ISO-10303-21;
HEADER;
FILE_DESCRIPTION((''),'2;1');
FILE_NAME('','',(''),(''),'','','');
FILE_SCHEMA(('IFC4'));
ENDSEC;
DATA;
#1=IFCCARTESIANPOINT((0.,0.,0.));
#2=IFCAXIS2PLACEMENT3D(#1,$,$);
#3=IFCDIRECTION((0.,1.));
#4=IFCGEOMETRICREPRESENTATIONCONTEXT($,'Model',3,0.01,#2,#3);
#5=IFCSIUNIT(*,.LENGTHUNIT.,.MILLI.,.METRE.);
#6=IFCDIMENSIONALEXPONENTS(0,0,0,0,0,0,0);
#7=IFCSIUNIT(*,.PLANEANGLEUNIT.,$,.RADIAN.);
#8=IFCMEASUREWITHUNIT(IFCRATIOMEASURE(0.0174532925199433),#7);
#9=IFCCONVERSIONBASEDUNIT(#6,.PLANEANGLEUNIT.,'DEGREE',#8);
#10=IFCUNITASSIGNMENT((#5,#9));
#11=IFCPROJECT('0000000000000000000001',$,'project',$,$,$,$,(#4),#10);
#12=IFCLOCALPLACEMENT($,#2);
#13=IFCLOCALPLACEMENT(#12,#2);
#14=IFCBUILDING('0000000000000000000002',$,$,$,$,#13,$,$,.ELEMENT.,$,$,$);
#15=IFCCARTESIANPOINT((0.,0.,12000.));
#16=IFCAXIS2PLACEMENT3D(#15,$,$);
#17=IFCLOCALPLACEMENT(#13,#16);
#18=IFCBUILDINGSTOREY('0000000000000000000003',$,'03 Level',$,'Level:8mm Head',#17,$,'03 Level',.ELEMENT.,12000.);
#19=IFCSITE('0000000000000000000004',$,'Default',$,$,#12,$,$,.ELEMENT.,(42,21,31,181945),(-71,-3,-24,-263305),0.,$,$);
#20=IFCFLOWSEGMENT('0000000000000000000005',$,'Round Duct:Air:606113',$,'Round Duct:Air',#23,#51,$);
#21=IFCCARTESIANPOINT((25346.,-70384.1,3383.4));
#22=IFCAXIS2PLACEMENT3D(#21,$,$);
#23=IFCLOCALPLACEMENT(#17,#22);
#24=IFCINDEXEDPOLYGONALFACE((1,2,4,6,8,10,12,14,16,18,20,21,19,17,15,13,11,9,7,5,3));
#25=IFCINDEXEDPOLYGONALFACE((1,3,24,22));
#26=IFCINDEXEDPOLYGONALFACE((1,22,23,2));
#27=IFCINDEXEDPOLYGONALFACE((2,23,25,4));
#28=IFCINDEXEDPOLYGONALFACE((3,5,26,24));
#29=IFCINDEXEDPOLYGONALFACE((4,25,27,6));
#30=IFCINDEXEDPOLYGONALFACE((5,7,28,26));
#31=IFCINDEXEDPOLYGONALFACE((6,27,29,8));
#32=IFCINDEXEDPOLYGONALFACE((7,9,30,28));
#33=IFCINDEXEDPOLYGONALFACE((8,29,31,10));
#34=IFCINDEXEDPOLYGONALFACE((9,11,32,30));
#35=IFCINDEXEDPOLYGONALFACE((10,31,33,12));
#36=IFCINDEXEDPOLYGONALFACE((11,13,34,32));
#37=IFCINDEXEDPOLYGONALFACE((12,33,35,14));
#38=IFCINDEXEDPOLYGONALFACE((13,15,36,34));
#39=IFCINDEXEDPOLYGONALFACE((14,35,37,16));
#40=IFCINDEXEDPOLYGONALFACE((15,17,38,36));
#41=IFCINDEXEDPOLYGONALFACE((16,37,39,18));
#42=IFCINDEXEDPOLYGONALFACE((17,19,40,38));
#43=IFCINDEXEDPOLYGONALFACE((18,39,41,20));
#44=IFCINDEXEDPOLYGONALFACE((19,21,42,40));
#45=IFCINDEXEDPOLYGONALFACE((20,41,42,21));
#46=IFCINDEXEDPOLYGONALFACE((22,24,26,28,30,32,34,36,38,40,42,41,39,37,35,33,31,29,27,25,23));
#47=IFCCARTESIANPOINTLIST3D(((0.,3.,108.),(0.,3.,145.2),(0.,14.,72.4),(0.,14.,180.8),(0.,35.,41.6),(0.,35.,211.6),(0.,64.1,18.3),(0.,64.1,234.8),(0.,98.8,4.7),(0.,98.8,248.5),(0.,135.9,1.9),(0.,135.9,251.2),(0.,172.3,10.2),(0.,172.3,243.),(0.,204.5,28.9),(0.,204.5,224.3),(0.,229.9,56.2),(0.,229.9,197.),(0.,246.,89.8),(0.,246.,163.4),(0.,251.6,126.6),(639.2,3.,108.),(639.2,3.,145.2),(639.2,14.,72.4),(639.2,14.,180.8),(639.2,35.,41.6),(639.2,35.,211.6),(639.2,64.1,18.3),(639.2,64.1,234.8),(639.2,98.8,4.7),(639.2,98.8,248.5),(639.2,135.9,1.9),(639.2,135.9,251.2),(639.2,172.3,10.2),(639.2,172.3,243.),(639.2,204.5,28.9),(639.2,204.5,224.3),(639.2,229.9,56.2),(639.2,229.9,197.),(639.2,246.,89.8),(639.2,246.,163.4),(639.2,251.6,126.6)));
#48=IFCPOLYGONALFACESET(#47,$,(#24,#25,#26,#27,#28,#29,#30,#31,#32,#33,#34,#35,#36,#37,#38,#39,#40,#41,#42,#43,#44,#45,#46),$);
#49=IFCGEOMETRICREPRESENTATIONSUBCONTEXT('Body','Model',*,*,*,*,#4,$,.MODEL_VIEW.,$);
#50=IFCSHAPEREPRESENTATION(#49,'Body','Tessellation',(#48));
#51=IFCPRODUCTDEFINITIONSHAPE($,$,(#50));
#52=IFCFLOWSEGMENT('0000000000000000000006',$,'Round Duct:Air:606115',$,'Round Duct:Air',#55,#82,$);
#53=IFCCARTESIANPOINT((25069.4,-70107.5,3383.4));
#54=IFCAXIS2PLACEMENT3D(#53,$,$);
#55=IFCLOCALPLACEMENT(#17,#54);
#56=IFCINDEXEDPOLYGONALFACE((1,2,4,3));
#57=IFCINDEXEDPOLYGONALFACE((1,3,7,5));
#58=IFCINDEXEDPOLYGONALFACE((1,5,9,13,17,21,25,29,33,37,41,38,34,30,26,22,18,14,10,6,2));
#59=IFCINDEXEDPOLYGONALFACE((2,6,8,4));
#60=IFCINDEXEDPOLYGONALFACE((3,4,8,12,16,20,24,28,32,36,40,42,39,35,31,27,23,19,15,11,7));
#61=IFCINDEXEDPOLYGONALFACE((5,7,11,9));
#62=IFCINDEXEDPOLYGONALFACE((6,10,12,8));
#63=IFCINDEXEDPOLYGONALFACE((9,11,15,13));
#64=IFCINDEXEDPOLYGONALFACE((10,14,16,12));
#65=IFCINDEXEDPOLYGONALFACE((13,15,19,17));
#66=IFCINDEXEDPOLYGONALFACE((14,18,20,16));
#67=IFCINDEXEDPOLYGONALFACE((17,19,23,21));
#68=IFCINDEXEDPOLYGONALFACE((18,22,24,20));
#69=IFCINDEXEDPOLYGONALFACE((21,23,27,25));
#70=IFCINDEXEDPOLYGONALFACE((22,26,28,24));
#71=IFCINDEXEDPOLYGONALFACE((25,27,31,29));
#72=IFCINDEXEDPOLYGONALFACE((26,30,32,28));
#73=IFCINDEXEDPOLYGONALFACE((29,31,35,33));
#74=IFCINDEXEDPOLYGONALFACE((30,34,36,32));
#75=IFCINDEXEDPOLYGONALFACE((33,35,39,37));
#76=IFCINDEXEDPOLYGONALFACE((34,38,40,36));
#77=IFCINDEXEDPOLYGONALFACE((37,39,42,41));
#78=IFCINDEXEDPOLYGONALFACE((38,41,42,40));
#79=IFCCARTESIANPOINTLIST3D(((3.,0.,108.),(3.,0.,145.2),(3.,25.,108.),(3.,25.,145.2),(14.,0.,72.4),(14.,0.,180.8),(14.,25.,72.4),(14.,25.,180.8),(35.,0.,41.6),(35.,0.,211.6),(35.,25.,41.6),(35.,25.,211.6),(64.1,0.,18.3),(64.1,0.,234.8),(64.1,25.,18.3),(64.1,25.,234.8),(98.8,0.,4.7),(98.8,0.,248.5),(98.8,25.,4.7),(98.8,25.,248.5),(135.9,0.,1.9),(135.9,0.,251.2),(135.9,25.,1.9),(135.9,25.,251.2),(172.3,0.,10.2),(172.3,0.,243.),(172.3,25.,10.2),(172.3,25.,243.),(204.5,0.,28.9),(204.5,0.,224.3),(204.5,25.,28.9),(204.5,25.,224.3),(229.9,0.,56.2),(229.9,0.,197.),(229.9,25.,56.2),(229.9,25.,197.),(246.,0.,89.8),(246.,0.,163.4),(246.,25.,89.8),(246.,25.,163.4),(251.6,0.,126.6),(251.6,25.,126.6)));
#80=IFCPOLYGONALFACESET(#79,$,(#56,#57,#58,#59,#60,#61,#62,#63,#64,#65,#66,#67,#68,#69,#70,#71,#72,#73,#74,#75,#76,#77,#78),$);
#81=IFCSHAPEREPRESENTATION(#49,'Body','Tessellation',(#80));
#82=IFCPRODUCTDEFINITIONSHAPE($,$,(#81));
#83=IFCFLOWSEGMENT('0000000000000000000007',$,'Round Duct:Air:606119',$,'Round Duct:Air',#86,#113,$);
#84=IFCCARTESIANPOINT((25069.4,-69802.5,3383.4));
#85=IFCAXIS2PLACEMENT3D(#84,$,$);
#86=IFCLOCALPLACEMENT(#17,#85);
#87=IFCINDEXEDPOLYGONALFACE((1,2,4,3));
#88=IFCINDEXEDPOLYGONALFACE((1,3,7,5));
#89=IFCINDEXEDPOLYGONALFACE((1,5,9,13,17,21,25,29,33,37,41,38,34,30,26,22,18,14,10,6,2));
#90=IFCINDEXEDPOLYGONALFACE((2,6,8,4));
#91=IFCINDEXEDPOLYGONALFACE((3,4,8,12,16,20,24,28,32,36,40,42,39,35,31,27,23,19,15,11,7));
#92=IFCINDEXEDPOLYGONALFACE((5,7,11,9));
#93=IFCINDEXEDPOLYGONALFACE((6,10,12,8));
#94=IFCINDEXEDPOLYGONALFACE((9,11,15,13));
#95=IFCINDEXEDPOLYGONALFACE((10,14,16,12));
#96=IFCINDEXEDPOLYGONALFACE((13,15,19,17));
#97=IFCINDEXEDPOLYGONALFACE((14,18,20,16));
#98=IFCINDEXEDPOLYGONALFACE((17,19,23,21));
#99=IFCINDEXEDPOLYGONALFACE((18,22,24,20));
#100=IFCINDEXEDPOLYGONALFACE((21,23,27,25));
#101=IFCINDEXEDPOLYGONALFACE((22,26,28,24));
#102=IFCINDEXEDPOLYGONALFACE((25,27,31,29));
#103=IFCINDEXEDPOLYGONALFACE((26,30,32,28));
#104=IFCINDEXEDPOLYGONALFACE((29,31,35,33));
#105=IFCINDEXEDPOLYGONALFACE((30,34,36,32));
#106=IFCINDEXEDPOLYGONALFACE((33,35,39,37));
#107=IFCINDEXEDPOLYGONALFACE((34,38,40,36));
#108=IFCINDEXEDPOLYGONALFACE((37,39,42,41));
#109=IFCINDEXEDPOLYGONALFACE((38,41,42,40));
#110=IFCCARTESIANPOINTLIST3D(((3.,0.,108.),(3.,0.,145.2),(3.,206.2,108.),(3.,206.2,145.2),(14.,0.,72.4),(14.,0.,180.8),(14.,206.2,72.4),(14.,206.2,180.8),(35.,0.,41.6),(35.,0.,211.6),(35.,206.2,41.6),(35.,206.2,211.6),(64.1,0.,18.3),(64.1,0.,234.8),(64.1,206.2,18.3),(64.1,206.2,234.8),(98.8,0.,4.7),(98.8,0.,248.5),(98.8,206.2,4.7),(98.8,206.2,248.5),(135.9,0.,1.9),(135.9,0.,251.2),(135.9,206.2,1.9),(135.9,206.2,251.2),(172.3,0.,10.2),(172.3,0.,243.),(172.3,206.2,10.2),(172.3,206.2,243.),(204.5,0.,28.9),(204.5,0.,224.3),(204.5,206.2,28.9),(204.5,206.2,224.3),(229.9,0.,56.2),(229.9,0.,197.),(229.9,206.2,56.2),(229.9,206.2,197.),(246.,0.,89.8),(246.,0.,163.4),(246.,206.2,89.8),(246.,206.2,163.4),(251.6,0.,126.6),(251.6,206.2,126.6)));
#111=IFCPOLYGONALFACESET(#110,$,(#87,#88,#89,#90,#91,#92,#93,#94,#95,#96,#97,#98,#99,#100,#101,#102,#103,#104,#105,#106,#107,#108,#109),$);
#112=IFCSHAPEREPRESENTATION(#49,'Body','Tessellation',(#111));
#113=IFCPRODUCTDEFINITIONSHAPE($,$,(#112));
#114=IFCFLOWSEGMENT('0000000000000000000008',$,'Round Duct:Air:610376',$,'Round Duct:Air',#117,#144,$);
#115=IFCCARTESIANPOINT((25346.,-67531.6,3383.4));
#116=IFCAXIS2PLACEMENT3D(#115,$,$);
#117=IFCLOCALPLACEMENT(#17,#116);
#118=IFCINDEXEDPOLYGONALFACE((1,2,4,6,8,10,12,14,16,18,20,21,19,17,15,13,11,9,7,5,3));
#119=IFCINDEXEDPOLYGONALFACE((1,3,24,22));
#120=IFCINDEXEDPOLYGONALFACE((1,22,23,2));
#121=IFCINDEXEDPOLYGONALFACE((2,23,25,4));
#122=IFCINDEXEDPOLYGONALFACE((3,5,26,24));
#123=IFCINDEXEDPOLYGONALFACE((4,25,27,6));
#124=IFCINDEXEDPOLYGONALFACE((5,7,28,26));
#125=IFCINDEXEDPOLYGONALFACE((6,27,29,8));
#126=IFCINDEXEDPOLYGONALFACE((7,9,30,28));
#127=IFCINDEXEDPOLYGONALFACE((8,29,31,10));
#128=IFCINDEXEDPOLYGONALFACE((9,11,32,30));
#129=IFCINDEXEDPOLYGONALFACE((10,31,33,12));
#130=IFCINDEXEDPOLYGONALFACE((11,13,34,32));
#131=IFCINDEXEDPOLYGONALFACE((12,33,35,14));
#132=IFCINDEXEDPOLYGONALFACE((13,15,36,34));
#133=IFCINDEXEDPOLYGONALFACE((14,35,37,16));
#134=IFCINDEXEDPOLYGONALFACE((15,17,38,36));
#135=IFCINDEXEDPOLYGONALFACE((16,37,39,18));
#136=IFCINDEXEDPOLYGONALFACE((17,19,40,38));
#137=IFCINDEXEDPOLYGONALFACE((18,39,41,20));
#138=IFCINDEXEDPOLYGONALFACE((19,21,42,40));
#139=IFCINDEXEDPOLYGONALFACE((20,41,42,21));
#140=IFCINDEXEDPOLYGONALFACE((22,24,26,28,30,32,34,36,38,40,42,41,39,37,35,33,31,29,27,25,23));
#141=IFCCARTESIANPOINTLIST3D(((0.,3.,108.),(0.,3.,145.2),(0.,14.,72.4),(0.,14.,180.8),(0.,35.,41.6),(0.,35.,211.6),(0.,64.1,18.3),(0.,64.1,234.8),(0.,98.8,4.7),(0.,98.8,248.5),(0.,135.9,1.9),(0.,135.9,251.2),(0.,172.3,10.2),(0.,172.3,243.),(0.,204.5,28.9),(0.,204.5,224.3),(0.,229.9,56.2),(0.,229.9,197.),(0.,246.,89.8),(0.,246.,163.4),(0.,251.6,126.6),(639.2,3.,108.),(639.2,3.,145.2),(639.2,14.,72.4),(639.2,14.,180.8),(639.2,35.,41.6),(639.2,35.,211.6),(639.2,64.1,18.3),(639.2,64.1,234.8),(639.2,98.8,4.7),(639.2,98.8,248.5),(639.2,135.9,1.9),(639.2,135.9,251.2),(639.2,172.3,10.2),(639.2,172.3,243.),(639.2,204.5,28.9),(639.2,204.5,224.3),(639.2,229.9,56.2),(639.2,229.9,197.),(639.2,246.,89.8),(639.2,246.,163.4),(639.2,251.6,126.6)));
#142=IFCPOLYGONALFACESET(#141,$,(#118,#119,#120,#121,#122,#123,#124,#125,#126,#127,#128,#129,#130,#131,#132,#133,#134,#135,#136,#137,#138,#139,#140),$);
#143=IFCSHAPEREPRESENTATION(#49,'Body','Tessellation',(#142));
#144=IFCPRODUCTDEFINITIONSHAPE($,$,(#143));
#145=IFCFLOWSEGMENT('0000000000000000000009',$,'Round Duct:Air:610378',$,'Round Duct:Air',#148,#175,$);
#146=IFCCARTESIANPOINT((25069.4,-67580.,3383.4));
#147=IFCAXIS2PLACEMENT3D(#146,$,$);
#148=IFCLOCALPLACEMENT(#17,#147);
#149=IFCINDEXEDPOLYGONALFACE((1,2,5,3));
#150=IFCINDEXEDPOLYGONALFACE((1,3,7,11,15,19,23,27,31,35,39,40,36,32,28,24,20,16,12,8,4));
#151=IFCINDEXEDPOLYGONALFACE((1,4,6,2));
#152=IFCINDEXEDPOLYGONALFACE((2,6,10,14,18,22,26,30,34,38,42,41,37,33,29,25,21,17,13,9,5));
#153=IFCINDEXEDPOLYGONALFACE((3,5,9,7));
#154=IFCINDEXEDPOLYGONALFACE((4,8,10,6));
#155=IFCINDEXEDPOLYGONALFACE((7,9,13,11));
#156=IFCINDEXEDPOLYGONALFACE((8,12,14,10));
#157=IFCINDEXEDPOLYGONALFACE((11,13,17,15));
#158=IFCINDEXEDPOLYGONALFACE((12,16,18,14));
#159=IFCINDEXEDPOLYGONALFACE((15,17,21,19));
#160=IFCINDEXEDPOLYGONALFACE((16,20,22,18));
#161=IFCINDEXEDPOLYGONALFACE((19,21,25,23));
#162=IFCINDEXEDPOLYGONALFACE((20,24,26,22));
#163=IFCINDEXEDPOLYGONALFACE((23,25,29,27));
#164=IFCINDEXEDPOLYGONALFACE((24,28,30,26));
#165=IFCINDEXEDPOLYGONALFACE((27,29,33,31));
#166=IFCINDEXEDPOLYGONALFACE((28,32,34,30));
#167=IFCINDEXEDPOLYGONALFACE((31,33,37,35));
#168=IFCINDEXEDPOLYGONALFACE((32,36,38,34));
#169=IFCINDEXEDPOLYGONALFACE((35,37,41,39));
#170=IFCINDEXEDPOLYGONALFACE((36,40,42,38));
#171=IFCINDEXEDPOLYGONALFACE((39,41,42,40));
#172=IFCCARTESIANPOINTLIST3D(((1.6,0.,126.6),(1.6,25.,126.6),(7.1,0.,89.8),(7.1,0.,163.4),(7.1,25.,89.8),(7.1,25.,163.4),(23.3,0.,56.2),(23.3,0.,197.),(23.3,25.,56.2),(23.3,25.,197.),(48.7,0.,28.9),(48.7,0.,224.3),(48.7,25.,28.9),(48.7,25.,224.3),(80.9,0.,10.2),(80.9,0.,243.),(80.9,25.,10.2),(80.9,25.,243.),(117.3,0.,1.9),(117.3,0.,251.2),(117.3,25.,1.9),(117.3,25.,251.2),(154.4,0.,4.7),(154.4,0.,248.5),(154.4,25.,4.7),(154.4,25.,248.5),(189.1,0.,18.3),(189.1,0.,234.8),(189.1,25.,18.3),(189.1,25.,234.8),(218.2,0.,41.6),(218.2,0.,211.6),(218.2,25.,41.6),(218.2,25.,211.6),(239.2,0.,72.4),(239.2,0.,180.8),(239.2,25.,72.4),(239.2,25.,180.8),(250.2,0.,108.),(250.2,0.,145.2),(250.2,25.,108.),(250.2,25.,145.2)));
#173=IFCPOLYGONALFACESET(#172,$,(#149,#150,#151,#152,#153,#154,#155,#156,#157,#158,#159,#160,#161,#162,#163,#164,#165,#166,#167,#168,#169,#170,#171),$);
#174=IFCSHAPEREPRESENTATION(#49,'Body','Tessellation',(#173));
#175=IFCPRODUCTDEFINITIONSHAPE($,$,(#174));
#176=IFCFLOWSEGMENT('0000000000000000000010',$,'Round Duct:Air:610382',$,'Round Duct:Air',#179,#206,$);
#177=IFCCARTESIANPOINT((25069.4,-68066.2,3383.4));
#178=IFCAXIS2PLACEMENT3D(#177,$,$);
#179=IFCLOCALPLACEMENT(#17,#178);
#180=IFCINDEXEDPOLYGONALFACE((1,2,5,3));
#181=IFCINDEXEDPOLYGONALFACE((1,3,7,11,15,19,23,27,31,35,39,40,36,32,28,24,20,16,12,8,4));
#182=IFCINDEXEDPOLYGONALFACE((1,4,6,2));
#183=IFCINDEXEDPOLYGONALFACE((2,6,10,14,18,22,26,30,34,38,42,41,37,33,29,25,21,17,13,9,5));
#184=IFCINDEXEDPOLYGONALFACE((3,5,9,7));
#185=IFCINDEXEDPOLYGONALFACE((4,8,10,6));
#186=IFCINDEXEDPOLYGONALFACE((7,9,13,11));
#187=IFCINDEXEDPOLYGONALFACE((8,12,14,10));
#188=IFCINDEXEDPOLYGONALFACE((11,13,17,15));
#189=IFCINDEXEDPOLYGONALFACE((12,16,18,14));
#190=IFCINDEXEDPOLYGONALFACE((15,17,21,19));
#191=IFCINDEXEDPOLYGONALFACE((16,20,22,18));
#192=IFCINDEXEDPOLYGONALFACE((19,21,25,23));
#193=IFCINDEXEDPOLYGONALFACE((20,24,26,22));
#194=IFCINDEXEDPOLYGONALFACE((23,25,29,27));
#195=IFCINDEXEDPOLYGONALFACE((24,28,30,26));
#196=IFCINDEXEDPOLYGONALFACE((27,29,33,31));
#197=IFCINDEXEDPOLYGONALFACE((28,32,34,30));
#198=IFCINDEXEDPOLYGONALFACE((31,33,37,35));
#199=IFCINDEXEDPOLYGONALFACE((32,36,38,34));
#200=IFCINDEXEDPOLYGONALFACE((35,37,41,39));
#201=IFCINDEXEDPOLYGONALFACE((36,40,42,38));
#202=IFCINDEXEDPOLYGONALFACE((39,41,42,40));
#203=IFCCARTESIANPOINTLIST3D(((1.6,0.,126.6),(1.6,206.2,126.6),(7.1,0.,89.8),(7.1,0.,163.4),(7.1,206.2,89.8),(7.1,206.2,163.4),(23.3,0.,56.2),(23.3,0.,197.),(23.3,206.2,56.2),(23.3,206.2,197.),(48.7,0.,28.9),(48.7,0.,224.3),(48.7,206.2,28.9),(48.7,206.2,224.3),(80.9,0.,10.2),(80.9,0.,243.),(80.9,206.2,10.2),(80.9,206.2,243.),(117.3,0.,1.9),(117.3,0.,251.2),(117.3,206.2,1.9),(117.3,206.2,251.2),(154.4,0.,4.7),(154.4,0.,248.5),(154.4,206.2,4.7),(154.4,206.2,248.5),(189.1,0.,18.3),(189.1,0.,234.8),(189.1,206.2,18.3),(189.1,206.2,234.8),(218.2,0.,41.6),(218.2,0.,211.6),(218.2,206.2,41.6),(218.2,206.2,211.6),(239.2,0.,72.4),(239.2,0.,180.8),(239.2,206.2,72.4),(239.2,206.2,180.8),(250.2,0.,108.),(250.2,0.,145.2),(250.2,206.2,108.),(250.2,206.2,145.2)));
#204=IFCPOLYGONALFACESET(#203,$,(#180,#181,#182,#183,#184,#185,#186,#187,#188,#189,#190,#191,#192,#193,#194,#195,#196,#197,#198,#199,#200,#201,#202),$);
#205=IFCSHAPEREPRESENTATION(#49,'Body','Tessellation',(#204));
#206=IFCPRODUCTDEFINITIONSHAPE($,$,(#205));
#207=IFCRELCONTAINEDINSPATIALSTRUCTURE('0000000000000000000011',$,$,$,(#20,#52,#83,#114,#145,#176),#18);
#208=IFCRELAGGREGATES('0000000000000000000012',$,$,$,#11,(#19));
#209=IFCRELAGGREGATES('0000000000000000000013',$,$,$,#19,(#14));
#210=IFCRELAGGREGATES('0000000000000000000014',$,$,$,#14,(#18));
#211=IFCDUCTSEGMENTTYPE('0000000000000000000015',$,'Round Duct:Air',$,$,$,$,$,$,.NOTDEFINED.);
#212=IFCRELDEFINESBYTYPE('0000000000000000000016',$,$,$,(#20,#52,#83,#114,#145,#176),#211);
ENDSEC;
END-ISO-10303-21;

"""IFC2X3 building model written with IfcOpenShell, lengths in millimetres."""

from ifc_helpers import new_model, entity, si_unit, converted_unit, direction, frame, frame_2d, origin, origin_2d_with_axis, place, context, subcontext, project, spatial, circle, extrude, type_object, element, save


model = new_model("IFC2X3")

# Units and contexts
model_context = context("Model", 3, precision=0.01, world=origin(), true_north=direction((0.0, 1.0)))
body_context = subcontext(model_context, "Body", "Model", "MODEL_VIEW")
ifc_project = project(units=[si_unit("LENGTHUNIT", "METRE", prefix="MILLI"), converted_unit("PLANEANGLEUNIT", "DEGREE", entity("IfcRatioMeasure", 0.0174532925199433), si_unit("PLANEANGLEUNIT", "RADIAN"), dimensions=[0, 0, 0, 0, 0, 0, 0])], contexts=[model_context])

# Site, building, storey
site_placement = place(None, origin())
site = spatial("IfcSite", under=ifc_project, at=site_placement, Name="Default", CompositionType="ELEMENT", RefLatitude=(42, 21, 31, 181945), RefLongitude=(-71, -3, -24, -263305), RefElevation=0.0)
building_placement = place(site_placement, origin())
building = spatial("IfcBuilding", under=site, at=building_placement, CompositionType="ELEMENT")
storey_placement = place(building_placement, frame((0.0, 0.0, 12000.0)))
storey = spatial("IfcBuildingStorey", under=building, at=storey_placement, Name="03 Level", ObjectType="Level:8mm Head", LongName="03 Level", CompositionType="ELEMENT", Elevation=12000.0)

# Flow segments
duct_segment_type = type_object("IfcDuctSegmentType", Name="Round Duct:Air", PredefinedType="NOTDEFINED")
flow_segment_1_placement = place(storey_placement, frame((25346.0, -70384.1, 3383.4)))
element("IfcFlowSegment", 1, at=flow_segment_1_placement, inside=storey, type_object=duct_segment_type, Name="Round Duct:Air:606113", ObjectType="Round Duct:Air", context=body_context, shape_type="SweptSolid", body=[
    extrude(circle(Radius=125.0, at=frame_2d((0.0, 0.0), x_axis=(1.0, 0.0))), frame((0.0, 126.6, 126.6), z_axis=(1.0, 0.0, 0.0), x_axis=(0.0, 1.0, 0.0)), (0.0, 0.0, 1.0), 639.2),
])
flow_segment_2_placement = place(storey_placement, frame((25069.4, -70107.5, 3383.4)))
element("IfcFlowSegment", 2, at=flow_segment_2_placement, inside=storey, type_object=duct_segment_type, Name="Round Duct:Air:606115", ObjectType="Round Duct:Air", context=body_context, shape_type="SweptSolid", body=[
    extrude(circle(Radius=125.0, at=origin_2d_with_axis()), frame((126.6, 0.0, 126.6), z_axis=(0.0, 1.0, 0.0), x_axis=(1.0, 0.0, 0.0)), (0.0, 0.0, 1.0), 25.0),
])
flow_segment_3_placement = place(storey_placement, frame((25069.4, -69802.5, 3383.4)))
element("IfcFlowSegment", 3, at=flow_segment_3_placement, inside=storey, type_object=duct_segment_type, Name="Round Duct:Air:606119", ObjectType="Round Duct:Air", context=body_context, shape_type="SweptSolid", body=[
    extrude(circle(Radius=125.0, at=origin_2d_with_axis()), frame((126.6, 0.0, 126.6), z_axis=(0.0, 1.0, 0.0), x_axis=(1.0, 0.0, 0.0)), (0.0, 0.0, 1.0), 206.2),
])
flow_segment_4_placement = place(storey_placement, frame((25346.0, -67531.6, 3383.4)))
element("IfcFlowSegment", 4, at=flow_segment_4_placement, inside=storey, type_object=duct_segment_type, Name="Round Duct:Air:610376", ObjectType="Round Duct:Air", context=body_context, shape_type="SweptSolid", body=[
    extrude(circle(Radius=125.0, at=frame_2d((0.0, 0.0), x_axis=(1.0, 0.0))), frame((0.0, 126.6, 126.6), z_axis=(1.0, 0.0, 0.0), x_axis=(0.0, 1.0, 0.0)), (0.0, 0.0, 1.0), 639.2),
])
flow_segment_5_placement = place(storey_placement, frame((25069.4, -67580.0, 3383.4)))
element("IfcFlowSegment", 5, at=flow_segment_5_placement, inside=storey, type_object=duct_segment_type, Name="Round Duct:Air:610378", ObjectType="Round Duct:Air", context=body_context, shape_type="SweptSolid", body=[
    extrude(circle(Radius=125.0, at=frame_2d((0.0, 0.0), x_axis=(1.0, 0.0))), frame((126.6, 0.0, 126.6), z_axis=(0.0, 1.0, 0.0), x_axis=(-1.0, 0.0, 0.0)), (0.0, 0.0, 1.0), 25.0),
])
flow_segment_6_placement = place(storey_placement, frame((25069.4, -68066.2, 3383.4)))
element("IfcFlowSegment", 6, at=flow_segment_6_placement, inside=storey, type_object=duct_segment_type, Name="Round Duct:Air:610382", ObjectType="Round Duct:Air", context=body_context, shape_type="SweptSolid", body=[
    extrude(circle(Radius=125.0, at=frame_2d((0.0, 0.0), x_axis=(1.0, 0.0))), frame((126.6, 0.0, 126.6), z_axis=(0.0, 1.0, 0.0), x_axis=(-1.0, 0.0, 0.0)), (0.0, 0.0, 1.0), 206.2),
])

save(model, "model.ifc")
